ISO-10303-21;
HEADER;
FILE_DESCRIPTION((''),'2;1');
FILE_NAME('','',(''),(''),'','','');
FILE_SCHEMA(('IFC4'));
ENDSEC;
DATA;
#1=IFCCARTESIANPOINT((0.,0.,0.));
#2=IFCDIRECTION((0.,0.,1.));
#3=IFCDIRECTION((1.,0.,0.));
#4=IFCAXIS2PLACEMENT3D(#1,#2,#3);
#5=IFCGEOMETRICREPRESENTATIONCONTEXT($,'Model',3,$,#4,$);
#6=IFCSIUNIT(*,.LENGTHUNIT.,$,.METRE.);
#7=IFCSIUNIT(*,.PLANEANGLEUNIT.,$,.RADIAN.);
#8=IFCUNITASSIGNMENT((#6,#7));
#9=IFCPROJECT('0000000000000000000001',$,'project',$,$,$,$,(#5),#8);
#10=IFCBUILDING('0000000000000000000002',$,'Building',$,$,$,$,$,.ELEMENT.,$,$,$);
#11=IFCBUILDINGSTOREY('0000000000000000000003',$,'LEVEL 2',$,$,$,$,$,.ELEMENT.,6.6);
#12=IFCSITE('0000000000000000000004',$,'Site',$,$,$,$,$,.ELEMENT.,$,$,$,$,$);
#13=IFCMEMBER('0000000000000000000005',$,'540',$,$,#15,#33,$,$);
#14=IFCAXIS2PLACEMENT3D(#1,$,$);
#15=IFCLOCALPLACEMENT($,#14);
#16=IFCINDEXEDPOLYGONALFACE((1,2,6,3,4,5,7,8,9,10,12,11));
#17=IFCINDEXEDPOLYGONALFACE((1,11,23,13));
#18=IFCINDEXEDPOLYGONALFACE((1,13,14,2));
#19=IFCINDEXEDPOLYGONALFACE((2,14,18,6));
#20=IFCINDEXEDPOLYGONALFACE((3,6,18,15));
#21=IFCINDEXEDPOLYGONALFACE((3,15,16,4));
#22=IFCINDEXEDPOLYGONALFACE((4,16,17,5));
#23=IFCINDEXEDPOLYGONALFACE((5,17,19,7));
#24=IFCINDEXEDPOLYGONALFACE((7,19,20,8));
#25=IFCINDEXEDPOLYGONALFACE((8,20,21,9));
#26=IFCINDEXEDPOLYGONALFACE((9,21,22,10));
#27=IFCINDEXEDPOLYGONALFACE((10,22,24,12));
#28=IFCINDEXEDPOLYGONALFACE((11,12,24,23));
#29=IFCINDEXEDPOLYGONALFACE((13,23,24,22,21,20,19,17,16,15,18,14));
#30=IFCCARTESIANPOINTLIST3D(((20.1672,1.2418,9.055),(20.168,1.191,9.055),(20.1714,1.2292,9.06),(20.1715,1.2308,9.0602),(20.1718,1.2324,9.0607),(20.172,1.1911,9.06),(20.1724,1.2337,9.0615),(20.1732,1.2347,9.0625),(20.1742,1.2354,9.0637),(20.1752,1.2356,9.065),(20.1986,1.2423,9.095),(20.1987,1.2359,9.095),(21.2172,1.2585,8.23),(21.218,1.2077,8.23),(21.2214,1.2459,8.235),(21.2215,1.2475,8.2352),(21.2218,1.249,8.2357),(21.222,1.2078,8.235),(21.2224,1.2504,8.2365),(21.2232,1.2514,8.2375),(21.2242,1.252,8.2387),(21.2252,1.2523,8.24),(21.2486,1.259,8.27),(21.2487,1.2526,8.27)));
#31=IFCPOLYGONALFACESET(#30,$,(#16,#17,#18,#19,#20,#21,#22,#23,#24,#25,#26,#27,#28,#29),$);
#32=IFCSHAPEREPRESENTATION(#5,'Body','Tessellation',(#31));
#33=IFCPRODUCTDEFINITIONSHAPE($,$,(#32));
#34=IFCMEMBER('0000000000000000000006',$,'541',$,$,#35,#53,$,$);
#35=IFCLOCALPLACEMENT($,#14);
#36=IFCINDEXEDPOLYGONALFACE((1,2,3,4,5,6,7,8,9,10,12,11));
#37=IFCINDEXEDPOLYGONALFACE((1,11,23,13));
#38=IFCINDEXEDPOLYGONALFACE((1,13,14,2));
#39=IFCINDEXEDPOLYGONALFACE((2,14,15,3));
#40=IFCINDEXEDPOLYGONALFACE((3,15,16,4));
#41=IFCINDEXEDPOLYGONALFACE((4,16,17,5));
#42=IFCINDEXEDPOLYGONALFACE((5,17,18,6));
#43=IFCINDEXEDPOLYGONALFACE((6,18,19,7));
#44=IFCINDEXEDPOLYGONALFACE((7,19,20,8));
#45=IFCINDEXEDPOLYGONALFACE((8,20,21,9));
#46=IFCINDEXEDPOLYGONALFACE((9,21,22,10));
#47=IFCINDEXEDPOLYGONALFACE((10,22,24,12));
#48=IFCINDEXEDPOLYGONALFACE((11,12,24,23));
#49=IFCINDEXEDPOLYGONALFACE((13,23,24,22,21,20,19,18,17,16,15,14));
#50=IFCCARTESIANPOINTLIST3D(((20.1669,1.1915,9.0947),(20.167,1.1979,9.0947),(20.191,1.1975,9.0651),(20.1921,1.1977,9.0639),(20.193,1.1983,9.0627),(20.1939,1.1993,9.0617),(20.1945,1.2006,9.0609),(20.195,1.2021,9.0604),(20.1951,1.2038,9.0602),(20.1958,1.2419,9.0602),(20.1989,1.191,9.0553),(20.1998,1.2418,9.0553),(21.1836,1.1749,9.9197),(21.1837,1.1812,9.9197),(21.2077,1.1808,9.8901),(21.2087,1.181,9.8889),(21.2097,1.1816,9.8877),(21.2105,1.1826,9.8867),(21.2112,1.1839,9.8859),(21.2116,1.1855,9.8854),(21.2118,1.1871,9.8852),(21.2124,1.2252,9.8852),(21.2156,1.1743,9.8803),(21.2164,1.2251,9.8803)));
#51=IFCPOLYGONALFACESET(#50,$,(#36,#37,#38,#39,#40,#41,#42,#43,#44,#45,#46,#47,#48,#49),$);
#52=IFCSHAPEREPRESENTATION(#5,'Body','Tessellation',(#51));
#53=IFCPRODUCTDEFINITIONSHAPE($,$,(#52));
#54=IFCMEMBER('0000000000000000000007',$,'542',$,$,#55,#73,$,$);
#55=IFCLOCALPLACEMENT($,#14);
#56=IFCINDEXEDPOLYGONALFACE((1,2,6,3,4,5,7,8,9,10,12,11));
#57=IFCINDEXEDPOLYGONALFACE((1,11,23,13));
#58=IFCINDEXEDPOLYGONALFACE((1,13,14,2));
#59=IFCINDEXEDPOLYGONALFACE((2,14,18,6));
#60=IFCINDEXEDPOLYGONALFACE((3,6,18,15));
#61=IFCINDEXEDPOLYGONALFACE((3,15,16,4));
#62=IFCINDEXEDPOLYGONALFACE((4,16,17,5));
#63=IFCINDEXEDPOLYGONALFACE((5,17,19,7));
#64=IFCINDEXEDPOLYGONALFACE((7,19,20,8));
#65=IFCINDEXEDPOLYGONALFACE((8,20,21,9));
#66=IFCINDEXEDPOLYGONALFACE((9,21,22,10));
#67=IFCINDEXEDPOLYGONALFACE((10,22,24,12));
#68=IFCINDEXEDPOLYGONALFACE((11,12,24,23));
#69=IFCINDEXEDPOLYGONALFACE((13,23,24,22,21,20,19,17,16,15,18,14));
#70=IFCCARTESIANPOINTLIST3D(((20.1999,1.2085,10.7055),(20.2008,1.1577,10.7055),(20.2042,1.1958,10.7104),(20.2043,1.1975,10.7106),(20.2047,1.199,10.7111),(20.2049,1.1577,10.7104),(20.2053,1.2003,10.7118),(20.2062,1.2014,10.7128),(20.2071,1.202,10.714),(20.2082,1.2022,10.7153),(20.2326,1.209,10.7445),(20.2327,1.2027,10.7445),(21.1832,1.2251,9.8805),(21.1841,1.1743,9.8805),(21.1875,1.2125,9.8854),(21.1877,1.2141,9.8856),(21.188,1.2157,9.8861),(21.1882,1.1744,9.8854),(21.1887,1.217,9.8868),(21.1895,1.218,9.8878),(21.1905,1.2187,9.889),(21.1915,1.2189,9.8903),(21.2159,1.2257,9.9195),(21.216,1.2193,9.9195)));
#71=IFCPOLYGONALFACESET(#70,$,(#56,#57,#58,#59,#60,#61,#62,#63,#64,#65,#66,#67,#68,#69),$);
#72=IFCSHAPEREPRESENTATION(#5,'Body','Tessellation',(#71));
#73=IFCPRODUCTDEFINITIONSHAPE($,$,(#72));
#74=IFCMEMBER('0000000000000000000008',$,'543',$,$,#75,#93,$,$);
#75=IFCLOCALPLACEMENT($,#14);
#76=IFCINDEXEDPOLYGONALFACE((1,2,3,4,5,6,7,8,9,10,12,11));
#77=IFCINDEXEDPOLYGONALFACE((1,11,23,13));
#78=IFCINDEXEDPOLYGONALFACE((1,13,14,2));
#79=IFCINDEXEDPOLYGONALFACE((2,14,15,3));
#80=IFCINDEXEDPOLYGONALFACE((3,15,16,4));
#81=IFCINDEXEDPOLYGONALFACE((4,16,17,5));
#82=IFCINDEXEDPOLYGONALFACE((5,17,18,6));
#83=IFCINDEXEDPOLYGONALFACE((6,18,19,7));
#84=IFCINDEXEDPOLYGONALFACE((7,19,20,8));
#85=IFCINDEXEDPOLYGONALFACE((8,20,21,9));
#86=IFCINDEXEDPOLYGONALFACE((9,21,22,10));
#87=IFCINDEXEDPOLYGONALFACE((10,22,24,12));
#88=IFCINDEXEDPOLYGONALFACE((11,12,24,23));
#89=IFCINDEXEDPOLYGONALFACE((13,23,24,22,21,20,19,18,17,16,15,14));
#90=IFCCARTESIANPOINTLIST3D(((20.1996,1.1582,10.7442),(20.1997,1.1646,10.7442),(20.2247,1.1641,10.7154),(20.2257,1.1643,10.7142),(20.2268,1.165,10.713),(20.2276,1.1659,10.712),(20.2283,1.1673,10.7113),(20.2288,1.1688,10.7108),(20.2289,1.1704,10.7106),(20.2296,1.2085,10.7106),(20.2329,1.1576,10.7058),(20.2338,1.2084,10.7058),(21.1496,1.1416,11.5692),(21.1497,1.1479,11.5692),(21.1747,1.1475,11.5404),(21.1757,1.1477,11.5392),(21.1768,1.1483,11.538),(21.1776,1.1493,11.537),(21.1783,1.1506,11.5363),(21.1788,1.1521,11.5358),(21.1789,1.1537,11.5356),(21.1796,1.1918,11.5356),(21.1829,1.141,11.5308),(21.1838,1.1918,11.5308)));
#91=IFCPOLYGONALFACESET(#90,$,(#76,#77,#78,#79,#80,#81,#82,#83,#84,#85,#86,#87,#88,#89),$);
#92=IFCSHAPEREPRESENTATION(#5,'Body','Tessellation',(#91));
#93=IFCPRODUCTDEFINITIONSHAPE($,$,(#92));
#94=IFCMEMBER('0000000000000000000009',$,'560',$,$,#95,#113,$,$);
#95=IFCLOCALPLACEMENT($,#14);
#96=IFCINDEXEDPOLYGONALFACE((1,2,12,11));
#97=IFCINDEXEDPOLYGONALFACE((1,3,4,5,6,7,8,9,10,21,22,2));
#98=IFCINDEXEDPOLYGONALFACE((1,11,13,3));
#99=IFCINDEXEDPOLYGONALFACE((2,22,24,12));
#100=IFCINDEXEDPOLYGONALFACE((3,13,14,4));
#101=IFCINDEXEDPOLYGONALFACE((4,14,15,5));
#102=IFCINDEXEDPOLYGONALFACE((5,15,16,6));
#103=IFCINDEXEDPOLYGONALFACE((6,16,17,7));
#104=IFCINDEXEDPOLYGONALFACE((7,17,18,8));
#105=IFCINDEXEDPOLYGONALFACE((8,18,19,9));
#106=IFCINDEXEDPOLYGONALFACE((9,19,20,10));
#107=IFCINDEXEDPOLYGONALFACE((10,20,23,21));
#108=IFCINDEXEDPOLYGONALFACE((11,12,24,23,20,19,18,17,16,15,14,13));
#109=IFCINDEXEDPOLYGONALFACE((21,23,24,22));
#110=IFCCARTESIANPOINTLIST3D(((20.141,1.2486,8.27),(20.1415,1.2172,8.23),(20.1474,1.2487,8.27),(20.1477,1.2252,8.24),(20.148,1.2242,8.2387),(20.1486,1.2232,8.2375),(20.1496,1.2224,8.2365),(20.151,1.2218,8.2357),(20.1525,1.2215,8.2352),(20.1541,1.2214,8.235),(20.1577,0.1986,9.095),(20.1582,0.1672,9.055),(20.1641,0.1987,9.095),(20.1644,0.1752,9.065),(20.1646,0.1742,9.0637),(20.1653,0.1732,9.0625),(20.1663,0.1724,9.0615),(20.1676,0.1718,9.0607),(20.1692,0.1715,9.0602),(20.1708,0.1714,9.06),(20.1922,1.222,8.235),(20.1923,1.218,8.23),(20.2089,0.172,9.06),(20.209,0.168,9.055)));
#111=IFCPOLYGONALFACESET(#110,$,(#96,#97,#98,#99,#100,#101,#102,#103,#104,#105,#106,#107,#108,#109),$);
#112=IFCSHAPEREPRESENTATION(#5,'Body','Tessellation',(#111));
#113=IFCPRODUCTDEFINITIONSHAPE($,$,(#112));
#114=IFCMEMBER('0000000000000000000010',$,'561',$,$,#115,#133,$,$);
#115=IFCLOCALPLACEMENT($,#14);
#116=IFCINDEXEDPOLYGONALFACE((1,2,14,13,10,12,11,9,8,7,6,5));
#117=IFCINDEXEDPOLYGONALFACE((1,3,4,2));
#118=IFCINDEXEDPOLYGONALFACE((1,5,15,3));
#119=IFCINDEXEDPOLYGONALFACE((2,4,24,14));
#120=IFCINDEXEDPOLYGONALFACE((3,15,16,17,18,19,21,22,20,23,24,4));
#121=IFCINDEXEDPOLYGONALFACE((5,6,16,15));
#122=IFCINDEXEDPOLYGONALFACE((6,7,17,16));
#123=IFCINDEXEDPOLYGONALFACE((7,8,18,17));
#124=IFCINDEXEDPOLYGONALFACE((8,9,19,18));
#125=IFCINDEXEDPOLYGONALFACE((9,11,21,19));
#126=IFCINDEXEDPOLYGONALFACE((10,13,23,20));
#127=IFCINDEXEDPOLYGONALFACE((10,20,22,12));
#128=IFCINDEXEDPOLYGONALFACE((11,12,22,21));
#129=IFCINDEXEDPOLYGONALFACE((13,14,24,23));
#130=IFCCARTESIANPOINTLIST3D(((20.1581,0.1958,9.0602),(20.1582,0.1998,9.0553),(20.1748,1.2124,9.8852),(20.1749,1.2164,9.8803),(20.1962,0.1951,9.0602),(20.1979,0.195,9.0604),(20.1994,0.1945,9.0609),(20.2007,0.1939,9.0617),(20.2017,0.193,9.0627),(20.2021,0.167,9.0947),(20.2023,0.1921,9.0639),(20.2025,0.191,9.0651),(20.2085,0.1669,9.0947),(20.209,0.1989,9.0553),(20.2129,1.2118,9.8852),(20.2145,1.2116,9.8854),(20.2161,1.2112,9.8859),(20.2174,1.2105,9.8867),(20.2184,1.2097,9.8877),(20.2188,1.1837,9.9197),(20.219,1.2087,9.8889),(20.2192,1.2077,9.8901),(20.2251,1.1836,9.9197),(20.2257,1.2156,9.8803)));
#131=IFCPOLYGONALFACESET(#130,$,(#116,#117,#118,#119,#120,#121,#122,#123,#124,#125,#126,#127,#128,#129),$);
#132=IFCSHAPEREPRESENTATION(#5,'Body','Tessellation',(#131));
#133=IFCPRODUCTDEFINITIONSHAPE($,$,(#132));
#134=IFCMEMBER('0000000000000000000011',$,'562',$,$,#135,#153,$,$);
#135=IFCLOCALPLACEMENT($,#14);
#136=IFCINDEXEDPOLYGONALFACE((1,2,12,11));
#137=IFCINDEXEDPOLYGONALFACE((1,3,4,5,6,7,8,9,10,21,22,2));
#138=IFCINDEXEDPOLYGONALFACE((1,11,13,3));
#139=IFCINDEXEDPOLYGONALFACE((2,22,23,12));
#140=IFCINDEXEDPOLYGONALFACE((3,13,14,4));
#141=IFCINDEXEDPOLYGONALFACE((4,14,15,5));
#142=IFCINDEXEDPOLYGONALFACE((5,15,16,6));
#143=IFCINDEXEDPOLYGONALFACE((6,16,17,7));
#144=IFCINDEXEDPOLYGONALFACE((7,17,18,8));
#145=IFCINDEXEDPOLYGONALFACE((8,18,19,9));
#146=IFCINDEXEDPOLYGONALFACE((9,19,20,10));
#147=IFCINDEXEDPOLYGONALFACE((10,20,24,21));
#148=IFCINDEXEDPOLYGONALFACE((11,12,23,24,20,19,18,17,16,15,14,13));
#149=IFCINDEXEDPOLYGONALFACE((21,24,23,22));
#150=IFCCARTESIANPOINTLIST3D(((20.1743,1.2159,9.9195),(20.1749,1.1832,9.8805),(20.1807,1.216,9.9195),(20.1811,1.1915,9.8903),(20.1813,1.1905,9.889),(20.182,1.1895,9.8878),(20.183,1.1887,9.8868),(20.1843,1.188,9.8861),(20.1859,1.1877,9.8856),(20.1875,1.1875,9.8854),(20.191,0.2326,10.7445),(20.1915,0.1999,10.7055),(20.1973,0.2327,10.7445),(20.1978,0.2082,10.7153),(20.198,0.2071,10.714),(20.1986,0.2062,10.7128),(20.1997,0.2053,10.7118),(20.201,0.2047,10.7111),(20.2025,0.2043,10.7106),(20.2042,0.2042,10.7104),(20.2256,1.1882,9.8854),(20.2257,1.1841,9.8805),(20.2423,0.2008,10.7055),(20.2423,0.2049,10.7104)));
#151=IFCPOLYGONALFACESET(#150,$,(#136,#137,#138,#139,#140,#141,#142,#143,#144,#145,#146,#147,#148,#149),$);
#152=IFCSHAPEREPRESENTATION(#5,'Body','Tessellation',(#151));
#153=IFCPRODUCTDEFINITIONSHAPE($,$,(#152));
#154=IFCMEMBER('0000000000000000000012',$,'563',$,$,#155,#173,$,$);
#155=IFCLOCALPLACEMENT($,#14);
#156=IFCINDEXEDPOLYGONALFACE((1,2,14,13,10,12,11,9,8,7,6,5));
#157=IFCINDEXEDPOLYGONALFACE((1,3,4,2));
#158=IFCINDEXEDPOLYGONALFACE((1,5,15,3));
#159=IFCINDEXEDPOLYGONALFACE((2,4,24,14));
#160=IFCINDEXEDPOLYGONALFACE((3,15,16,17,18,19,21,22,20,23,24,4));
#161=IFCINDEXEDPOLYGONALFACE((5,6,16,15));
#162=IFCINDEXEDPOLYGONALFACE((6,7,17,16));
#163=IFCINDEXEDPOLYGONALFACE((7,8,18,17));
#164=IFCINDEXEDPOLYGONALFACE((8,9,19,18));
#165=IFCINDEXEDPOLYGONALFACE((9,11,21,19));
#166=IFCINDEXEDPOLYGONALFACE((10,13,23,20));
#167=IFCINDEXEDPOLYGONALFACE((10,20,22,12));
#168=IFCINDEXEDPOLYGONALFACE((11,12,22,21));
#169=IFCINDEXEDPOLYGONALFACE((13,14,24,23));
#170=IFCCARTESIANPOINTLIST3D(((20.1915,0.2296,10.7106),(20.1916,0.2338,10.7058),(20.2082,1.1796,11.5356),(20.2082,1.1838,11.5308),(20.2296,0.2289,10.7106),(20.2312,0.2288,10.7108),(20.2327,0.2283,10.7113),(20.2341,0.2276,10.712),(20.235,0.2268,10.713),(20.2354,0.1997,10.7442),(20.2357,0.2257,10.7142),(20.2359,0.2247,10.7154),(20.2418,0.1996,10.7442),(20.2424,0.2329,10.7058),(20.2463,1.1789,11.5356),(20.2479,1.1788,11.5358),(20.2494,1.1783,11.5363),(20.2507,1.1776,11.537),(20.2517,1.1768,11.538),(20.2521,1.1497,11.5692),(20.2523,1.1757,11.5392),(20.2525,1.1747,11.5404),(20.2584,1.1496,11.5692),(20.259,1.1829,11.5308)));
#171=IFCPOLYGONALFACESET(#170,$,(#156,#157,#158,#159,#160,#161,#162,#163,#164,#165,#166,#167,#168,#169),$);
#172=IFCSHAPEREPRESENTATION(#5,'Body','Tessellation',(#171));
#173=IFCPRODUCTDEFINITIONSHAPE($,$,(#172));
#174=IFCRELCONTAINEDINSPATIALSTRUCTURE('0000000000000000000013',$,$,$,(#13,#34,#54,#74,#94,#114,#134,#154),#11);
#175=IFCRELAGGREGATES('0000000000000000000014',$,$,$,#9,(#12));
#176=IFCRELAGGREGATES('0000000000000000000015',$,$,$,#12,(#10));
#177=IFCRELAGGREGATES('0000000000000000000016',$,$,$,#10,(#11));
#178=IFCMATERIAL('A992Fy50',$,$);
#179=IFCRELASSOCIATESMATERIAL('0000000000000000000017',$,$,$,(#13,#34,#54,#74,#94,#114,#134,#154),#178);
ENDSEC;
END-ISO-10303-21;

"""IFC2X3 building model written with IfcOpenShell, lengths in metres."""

from ifc_helpers import new_model, si_unit, frame, origin_with_axes, origin_2d_with_axis, place, context, project, spatial, l_section, extrude, material, element, save


model = new_model("IFC2X3")

# Units and contexts
model_context = context("Model", 3, world=origin_with_axes())
ifc_project = project(units=[si_unit("LENGTHUNIT", "METRE"), si_unit("PLANEANGLEUNIT", "RADIAN")], contexts=[model_context])

# Site, building, storey
site = spatial("IfcSite", under=ifc_project, Name="Site", CompositionType="ELEMENT")
building = spatial("IfcBuilding", under=site, Name="Building", CompositionType="ELEMENT")
storey = spatial("IfcBuildingStorey", under=building, Name="LEVEL 2", CompositionType="ELEMENT", Elevation=6.6)

# Members
ifc_material = material(Name="A992Fy50")
member_1_placement = place(None, frame((21.2333, 1.2333, 8.25), z_axis=(-0.786257, -0.01248, 0.617773), x_axis=(0.014924, -0.999889, 0.0)))
element("IfcMember", 1, at=member_1_placement, inside=storey, material=ifc_material, Name="540", context=model_context, shape_type="SweptSolid", body=[
    extrude(l_section(Depth=0.0508, Width=0.0508, Thickness=0.0063, FilletRadius=0.0063, at=origin_2d_with_axis()), origin_with_axes(), (0.0, 0.0, 1.0), 1.3354),
])
member_2_placement = place(None, frame((20.1833, 1.2167, 9.075), z_axis=(0.77644, -0.012729, 0.630062), x_axis=(0.016391, 0.999866, 0.0)))
element("IfcMember", 2, at=member_2_placement, inside=storey, material=ifc_material, Name="541", context=model_context, shape_type="SweptSolid", body=[
    extrude(l_section(Depth=0.0508, Width=0.0508, Thickness=0.0063, FilletRadius=0.0063, at=origin_2d_with_axis()), origin_with_axes(), (0.0, 0.0, 1.0), 1.3094),
])
member_3_placement = place(None, frame((21.2, 1.2, 9.9), z_axis=(-0.766024, -0.012983, 0.642681), x_axis=(0.016947, -0.999856, 0.0)))
element("IfcMember", 3, at=member_3_placement, inside=storey, material=ifc_material, Name="542", context=model_context, shape_type="SweptSolid", body=[
    extrude(l_section(Depth=0.0508, Width=0.0508, Thickness=0.0063, FilletRadius=0.0063, at=origin_2d_with_axis()), origin_with_axes(), (0.0, 0.0, 1.0), 1.2837),
])
member_4_placement = place(None, frame((20.2167, 1.1833, 10.725), z_axis=(0.754967, -0.013245, 0.655629), x_axis=(0.017541, 0.999846, 0.0)))
element("IfcMember", 4, at=member_4_placement, inside=storey, material=ifc_material, Name="543", context=model_context, shape_type="SweptSolid", body=[
    extrude(l_section(Depth=0.0508, Width=0.0508, Thickness=0.0063, FilletRadius=0.0063, at=origin_2d_with_axis()), origin_with_axes(), (0.0, 0.0, 1.0), 1.2583),
])
member_5_placement = place(None, frame((20.1667, 1.2333, 8.25), z_axis=(0.01248, -0.786257, 0.617773), x_axis=(0.999889, 0.014924, 0.0)))
element("IfcMember", 5, at=member_5_placement, inside=storey, material=ifc_material, Name="560", context=model_context, shape_type="SweptSolid", body=[
    extrude(l_section(Depth=0.0508, Width=0.0508, Thickness=0.0063, FilletRadius=0.0063, at=origin_2d_with_axis()), origin_with_axes(), (0.0, 0.0, 1.0), 1.3354),
])
member_6_placement = place(None, frame((20.1833, 0.1833, 9.075), z_axis=(0.012729, 0.77644, 0.630062), x_axis=(-0.999866, 0.016391, 0.0)))
element("IfcMember", 6, at=member_6_placement, inside=storey, material=ifc_material, Name="561", context=model_context, shape_type="SweptSolid", body=[
    extrude(l_section(Depth=0.0508, Width=0.0508, Thickness=0.0063, FilletRadius=0.0063, at=origin_2d_with_axis()), origin_with_axes(), (0.0, 0.0, 1.0), 1.3094),
])
member_7_placement = place(None, frame((20.2, 1.2, 9.9), z_axis=(0.012983, -0.766024, 0.642681), x_axis=(0.999856, 0.016947, 0.0)))
element("IfcMember", 7, at=member_7_placement, inside=storey, material=ifc_material, Name="562", context=model_context, shape_type="SweptSolid", body=[
    extrude(l_section(Depth=0.0508, Width=0.0508, Thickness=0.0063, FilletRadius=0.0063, at=origin_2d_with_axis()), origin_with_axes(), (0.0, 0.0, 1.0), 1.2837),
])
member_8_placement = place(None, frame((20.2167, 0.2167, 10.725), z_axis=(0.013245, 0.754967, 0.655629), x_axis=(-0.999846, 0.017541, 0.0)))
element("IfcMember", 8, at=member_8_placement, inside=storey, material=ifc_material, Name="563", context=model_context, shape_type="SweptSolid", body=[
    extrude(l_section(Depth=0.0508, Width=0.0508, Thickness=0.0063, FilletRadius=0.0063, at=origin_2d_with_axis()), origin_with_axes(), (0.0, 0.0, 1.0), 1.2583),
])

save(model, "model.ifc")
